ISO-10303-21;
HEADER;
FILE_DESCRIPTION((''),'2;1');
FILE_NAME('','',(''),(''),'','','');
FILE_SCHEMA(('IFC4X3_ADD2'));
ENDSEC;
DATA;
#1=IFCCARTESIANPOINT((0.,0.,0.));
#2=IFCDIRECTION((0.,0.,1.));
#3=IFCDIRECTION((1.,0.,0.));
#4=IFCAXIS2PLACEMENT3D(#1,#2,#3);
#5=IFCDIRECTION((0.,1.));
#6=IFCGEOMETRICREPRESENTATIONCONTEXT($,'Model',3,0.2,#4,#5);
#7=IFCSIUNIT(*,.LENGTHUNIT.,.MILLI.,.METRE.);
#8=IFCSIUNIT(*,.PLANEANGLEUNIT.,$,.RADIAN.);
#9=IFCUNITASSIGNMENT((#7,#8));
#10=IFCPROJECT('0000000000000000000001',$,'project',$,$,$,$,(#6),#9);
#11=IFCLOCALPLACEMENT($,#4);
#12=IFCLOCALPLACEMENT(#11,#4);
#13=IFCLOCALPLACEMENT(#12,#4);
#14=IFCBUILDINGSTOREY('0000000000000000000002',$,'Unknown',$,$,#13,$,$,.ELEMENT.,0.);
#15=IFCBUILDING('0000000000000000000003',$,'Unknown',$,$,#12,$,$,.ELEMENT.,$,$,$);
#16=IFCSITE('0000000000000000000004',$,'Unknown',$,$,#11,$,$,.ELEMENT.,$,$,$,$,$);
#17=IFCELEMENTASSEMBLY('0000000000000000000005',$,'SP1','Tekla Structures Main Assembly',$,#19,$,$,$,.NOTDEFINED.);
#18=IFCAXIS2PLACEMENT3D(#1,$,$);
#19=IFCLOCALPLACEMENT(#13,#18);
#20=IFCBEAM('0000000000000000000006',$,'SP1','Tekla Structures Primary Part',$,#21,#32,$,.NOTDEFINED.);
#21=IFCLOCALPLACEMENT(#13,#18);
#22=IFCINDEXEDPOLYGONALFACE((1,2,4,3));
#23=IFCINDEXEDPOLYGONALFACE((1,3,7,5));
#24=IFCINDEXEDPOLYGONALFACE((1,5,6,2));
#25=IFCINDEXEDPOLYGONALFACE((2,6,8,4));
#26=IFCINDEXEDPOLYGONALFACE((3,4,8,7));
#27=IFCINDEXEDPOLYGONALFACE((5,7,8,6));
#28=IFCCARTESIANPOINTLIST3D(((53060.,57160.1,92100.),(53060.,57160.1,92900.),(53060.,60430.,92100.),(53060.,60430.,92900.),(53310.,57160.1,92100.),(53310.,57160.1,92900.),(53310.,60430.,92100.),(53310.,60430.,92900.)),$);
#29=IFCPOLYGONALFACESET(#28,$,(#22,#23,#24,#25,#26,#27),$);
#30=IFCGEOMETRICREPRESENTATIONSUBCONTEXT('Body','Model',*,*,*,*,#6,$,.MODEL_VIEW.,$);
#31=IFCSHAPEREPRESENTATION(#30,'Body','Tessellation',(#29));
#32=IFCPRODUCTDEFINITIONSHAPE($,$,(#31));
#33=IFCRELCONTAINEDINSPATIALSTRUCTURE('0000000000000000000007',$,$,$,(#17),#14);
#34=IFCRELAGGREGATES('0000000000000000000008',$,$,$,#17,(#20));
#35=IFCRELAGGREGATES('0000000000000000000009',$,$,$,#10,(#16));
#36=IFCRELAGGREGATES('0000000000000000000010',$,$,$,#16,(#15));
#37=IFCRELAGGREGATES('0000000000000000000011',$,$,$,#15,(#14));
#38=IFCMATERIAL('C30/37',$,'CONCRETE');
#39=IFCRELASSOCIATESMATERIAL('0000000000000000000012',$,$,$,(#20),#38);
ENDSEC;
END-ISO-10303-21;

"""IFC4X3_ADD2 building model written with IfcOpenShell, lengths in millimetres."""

from ifc_helpers import new_model, si_unit, direction, frame, origin_with_axes, place, context, subcontext, project, spatial, line, indexed_curve, outline, extrude, material, element, aggregate, save


model = new_model("IFC4X3_ADD2")

# Units and contexts
model_context = context("Model", 3, precision=0.2, world=origin_with_axes(), true_north=direction((0.0, 1.0)))
body_context = subcontext(model_context, "Body", "Model", "MODEL_VIEW")
ifc_project = project(units=[si_unit("LENGTHUNIT", "METRE", prefix="MILLI"), si_unit("PLANEANGLEUNIT", "RADIAN")], contexts=[model_context])

# Site, building, storey
site_placement = place(None, origin_with_axes())
site = spatial("IfcSite", under=ifc_project, at=site_placement, Name="Unknown", CompositionType="ELEMENT")
building_placement = place(site_placement, origin_with_axes())
building = spatial("IfcBuilding", under=site, at=building_placement, Name="Unknown", CompositionType="ELEMENT")
storey_placement = place(building_placement, origin_with_axes())
storey = spatial("IfcBuildingStorey", under=building, at=storey_placement, Name="Unknown", CompositionType="ELEMENT", Elevation=0.0)

# Shared definitions
ifc_material_1 = material(Name="C30/37", Category="CONCRETE")

# Element assembly, beam
assembly_1_placement = place(storey_placement, frame((53185.0, 60430.0, 92500.0), z_axis=(0.0, 0.0, 1.0), x_axis=(0.0, -1.0, 0.0)))
assembly_1 = element("IfcElementAssembly", 1, at=assembly_1_placement, inside=storey, Name="SP1", Description="Tekla Structures Main Assembly", PredefinedType="NOTDEFINED")
beam_1_placement = place(assembly_1_placement, origin_with_axes())
beam_1 = element("IfcBeam", 2, at=beam_1_placement, material=ifc_material_1, Name="SP1", Description="Tekla Structures Primary Part", PredefinedType="NOTDEFINED", context=body_context, shape_type="SolidModel", body=[
    extrude(outline(indexed_curve([(-400.0, -125.0), (400.0, -125.0), (400.0, 125.0), (-400.0, 125.0)], segments=[line(1, 2, 3, 4, 1)])), frame((0.0, 0.0, 0.0), z_axis=(-1.0, 0.0, 0.0), x_axis=(0.0, 0.0, 1.0)), (0.0, 0.0, -1.0), 3269.9),
])
aggregate(assembly_1, [beam_1])

save(model, "model.ifc")
